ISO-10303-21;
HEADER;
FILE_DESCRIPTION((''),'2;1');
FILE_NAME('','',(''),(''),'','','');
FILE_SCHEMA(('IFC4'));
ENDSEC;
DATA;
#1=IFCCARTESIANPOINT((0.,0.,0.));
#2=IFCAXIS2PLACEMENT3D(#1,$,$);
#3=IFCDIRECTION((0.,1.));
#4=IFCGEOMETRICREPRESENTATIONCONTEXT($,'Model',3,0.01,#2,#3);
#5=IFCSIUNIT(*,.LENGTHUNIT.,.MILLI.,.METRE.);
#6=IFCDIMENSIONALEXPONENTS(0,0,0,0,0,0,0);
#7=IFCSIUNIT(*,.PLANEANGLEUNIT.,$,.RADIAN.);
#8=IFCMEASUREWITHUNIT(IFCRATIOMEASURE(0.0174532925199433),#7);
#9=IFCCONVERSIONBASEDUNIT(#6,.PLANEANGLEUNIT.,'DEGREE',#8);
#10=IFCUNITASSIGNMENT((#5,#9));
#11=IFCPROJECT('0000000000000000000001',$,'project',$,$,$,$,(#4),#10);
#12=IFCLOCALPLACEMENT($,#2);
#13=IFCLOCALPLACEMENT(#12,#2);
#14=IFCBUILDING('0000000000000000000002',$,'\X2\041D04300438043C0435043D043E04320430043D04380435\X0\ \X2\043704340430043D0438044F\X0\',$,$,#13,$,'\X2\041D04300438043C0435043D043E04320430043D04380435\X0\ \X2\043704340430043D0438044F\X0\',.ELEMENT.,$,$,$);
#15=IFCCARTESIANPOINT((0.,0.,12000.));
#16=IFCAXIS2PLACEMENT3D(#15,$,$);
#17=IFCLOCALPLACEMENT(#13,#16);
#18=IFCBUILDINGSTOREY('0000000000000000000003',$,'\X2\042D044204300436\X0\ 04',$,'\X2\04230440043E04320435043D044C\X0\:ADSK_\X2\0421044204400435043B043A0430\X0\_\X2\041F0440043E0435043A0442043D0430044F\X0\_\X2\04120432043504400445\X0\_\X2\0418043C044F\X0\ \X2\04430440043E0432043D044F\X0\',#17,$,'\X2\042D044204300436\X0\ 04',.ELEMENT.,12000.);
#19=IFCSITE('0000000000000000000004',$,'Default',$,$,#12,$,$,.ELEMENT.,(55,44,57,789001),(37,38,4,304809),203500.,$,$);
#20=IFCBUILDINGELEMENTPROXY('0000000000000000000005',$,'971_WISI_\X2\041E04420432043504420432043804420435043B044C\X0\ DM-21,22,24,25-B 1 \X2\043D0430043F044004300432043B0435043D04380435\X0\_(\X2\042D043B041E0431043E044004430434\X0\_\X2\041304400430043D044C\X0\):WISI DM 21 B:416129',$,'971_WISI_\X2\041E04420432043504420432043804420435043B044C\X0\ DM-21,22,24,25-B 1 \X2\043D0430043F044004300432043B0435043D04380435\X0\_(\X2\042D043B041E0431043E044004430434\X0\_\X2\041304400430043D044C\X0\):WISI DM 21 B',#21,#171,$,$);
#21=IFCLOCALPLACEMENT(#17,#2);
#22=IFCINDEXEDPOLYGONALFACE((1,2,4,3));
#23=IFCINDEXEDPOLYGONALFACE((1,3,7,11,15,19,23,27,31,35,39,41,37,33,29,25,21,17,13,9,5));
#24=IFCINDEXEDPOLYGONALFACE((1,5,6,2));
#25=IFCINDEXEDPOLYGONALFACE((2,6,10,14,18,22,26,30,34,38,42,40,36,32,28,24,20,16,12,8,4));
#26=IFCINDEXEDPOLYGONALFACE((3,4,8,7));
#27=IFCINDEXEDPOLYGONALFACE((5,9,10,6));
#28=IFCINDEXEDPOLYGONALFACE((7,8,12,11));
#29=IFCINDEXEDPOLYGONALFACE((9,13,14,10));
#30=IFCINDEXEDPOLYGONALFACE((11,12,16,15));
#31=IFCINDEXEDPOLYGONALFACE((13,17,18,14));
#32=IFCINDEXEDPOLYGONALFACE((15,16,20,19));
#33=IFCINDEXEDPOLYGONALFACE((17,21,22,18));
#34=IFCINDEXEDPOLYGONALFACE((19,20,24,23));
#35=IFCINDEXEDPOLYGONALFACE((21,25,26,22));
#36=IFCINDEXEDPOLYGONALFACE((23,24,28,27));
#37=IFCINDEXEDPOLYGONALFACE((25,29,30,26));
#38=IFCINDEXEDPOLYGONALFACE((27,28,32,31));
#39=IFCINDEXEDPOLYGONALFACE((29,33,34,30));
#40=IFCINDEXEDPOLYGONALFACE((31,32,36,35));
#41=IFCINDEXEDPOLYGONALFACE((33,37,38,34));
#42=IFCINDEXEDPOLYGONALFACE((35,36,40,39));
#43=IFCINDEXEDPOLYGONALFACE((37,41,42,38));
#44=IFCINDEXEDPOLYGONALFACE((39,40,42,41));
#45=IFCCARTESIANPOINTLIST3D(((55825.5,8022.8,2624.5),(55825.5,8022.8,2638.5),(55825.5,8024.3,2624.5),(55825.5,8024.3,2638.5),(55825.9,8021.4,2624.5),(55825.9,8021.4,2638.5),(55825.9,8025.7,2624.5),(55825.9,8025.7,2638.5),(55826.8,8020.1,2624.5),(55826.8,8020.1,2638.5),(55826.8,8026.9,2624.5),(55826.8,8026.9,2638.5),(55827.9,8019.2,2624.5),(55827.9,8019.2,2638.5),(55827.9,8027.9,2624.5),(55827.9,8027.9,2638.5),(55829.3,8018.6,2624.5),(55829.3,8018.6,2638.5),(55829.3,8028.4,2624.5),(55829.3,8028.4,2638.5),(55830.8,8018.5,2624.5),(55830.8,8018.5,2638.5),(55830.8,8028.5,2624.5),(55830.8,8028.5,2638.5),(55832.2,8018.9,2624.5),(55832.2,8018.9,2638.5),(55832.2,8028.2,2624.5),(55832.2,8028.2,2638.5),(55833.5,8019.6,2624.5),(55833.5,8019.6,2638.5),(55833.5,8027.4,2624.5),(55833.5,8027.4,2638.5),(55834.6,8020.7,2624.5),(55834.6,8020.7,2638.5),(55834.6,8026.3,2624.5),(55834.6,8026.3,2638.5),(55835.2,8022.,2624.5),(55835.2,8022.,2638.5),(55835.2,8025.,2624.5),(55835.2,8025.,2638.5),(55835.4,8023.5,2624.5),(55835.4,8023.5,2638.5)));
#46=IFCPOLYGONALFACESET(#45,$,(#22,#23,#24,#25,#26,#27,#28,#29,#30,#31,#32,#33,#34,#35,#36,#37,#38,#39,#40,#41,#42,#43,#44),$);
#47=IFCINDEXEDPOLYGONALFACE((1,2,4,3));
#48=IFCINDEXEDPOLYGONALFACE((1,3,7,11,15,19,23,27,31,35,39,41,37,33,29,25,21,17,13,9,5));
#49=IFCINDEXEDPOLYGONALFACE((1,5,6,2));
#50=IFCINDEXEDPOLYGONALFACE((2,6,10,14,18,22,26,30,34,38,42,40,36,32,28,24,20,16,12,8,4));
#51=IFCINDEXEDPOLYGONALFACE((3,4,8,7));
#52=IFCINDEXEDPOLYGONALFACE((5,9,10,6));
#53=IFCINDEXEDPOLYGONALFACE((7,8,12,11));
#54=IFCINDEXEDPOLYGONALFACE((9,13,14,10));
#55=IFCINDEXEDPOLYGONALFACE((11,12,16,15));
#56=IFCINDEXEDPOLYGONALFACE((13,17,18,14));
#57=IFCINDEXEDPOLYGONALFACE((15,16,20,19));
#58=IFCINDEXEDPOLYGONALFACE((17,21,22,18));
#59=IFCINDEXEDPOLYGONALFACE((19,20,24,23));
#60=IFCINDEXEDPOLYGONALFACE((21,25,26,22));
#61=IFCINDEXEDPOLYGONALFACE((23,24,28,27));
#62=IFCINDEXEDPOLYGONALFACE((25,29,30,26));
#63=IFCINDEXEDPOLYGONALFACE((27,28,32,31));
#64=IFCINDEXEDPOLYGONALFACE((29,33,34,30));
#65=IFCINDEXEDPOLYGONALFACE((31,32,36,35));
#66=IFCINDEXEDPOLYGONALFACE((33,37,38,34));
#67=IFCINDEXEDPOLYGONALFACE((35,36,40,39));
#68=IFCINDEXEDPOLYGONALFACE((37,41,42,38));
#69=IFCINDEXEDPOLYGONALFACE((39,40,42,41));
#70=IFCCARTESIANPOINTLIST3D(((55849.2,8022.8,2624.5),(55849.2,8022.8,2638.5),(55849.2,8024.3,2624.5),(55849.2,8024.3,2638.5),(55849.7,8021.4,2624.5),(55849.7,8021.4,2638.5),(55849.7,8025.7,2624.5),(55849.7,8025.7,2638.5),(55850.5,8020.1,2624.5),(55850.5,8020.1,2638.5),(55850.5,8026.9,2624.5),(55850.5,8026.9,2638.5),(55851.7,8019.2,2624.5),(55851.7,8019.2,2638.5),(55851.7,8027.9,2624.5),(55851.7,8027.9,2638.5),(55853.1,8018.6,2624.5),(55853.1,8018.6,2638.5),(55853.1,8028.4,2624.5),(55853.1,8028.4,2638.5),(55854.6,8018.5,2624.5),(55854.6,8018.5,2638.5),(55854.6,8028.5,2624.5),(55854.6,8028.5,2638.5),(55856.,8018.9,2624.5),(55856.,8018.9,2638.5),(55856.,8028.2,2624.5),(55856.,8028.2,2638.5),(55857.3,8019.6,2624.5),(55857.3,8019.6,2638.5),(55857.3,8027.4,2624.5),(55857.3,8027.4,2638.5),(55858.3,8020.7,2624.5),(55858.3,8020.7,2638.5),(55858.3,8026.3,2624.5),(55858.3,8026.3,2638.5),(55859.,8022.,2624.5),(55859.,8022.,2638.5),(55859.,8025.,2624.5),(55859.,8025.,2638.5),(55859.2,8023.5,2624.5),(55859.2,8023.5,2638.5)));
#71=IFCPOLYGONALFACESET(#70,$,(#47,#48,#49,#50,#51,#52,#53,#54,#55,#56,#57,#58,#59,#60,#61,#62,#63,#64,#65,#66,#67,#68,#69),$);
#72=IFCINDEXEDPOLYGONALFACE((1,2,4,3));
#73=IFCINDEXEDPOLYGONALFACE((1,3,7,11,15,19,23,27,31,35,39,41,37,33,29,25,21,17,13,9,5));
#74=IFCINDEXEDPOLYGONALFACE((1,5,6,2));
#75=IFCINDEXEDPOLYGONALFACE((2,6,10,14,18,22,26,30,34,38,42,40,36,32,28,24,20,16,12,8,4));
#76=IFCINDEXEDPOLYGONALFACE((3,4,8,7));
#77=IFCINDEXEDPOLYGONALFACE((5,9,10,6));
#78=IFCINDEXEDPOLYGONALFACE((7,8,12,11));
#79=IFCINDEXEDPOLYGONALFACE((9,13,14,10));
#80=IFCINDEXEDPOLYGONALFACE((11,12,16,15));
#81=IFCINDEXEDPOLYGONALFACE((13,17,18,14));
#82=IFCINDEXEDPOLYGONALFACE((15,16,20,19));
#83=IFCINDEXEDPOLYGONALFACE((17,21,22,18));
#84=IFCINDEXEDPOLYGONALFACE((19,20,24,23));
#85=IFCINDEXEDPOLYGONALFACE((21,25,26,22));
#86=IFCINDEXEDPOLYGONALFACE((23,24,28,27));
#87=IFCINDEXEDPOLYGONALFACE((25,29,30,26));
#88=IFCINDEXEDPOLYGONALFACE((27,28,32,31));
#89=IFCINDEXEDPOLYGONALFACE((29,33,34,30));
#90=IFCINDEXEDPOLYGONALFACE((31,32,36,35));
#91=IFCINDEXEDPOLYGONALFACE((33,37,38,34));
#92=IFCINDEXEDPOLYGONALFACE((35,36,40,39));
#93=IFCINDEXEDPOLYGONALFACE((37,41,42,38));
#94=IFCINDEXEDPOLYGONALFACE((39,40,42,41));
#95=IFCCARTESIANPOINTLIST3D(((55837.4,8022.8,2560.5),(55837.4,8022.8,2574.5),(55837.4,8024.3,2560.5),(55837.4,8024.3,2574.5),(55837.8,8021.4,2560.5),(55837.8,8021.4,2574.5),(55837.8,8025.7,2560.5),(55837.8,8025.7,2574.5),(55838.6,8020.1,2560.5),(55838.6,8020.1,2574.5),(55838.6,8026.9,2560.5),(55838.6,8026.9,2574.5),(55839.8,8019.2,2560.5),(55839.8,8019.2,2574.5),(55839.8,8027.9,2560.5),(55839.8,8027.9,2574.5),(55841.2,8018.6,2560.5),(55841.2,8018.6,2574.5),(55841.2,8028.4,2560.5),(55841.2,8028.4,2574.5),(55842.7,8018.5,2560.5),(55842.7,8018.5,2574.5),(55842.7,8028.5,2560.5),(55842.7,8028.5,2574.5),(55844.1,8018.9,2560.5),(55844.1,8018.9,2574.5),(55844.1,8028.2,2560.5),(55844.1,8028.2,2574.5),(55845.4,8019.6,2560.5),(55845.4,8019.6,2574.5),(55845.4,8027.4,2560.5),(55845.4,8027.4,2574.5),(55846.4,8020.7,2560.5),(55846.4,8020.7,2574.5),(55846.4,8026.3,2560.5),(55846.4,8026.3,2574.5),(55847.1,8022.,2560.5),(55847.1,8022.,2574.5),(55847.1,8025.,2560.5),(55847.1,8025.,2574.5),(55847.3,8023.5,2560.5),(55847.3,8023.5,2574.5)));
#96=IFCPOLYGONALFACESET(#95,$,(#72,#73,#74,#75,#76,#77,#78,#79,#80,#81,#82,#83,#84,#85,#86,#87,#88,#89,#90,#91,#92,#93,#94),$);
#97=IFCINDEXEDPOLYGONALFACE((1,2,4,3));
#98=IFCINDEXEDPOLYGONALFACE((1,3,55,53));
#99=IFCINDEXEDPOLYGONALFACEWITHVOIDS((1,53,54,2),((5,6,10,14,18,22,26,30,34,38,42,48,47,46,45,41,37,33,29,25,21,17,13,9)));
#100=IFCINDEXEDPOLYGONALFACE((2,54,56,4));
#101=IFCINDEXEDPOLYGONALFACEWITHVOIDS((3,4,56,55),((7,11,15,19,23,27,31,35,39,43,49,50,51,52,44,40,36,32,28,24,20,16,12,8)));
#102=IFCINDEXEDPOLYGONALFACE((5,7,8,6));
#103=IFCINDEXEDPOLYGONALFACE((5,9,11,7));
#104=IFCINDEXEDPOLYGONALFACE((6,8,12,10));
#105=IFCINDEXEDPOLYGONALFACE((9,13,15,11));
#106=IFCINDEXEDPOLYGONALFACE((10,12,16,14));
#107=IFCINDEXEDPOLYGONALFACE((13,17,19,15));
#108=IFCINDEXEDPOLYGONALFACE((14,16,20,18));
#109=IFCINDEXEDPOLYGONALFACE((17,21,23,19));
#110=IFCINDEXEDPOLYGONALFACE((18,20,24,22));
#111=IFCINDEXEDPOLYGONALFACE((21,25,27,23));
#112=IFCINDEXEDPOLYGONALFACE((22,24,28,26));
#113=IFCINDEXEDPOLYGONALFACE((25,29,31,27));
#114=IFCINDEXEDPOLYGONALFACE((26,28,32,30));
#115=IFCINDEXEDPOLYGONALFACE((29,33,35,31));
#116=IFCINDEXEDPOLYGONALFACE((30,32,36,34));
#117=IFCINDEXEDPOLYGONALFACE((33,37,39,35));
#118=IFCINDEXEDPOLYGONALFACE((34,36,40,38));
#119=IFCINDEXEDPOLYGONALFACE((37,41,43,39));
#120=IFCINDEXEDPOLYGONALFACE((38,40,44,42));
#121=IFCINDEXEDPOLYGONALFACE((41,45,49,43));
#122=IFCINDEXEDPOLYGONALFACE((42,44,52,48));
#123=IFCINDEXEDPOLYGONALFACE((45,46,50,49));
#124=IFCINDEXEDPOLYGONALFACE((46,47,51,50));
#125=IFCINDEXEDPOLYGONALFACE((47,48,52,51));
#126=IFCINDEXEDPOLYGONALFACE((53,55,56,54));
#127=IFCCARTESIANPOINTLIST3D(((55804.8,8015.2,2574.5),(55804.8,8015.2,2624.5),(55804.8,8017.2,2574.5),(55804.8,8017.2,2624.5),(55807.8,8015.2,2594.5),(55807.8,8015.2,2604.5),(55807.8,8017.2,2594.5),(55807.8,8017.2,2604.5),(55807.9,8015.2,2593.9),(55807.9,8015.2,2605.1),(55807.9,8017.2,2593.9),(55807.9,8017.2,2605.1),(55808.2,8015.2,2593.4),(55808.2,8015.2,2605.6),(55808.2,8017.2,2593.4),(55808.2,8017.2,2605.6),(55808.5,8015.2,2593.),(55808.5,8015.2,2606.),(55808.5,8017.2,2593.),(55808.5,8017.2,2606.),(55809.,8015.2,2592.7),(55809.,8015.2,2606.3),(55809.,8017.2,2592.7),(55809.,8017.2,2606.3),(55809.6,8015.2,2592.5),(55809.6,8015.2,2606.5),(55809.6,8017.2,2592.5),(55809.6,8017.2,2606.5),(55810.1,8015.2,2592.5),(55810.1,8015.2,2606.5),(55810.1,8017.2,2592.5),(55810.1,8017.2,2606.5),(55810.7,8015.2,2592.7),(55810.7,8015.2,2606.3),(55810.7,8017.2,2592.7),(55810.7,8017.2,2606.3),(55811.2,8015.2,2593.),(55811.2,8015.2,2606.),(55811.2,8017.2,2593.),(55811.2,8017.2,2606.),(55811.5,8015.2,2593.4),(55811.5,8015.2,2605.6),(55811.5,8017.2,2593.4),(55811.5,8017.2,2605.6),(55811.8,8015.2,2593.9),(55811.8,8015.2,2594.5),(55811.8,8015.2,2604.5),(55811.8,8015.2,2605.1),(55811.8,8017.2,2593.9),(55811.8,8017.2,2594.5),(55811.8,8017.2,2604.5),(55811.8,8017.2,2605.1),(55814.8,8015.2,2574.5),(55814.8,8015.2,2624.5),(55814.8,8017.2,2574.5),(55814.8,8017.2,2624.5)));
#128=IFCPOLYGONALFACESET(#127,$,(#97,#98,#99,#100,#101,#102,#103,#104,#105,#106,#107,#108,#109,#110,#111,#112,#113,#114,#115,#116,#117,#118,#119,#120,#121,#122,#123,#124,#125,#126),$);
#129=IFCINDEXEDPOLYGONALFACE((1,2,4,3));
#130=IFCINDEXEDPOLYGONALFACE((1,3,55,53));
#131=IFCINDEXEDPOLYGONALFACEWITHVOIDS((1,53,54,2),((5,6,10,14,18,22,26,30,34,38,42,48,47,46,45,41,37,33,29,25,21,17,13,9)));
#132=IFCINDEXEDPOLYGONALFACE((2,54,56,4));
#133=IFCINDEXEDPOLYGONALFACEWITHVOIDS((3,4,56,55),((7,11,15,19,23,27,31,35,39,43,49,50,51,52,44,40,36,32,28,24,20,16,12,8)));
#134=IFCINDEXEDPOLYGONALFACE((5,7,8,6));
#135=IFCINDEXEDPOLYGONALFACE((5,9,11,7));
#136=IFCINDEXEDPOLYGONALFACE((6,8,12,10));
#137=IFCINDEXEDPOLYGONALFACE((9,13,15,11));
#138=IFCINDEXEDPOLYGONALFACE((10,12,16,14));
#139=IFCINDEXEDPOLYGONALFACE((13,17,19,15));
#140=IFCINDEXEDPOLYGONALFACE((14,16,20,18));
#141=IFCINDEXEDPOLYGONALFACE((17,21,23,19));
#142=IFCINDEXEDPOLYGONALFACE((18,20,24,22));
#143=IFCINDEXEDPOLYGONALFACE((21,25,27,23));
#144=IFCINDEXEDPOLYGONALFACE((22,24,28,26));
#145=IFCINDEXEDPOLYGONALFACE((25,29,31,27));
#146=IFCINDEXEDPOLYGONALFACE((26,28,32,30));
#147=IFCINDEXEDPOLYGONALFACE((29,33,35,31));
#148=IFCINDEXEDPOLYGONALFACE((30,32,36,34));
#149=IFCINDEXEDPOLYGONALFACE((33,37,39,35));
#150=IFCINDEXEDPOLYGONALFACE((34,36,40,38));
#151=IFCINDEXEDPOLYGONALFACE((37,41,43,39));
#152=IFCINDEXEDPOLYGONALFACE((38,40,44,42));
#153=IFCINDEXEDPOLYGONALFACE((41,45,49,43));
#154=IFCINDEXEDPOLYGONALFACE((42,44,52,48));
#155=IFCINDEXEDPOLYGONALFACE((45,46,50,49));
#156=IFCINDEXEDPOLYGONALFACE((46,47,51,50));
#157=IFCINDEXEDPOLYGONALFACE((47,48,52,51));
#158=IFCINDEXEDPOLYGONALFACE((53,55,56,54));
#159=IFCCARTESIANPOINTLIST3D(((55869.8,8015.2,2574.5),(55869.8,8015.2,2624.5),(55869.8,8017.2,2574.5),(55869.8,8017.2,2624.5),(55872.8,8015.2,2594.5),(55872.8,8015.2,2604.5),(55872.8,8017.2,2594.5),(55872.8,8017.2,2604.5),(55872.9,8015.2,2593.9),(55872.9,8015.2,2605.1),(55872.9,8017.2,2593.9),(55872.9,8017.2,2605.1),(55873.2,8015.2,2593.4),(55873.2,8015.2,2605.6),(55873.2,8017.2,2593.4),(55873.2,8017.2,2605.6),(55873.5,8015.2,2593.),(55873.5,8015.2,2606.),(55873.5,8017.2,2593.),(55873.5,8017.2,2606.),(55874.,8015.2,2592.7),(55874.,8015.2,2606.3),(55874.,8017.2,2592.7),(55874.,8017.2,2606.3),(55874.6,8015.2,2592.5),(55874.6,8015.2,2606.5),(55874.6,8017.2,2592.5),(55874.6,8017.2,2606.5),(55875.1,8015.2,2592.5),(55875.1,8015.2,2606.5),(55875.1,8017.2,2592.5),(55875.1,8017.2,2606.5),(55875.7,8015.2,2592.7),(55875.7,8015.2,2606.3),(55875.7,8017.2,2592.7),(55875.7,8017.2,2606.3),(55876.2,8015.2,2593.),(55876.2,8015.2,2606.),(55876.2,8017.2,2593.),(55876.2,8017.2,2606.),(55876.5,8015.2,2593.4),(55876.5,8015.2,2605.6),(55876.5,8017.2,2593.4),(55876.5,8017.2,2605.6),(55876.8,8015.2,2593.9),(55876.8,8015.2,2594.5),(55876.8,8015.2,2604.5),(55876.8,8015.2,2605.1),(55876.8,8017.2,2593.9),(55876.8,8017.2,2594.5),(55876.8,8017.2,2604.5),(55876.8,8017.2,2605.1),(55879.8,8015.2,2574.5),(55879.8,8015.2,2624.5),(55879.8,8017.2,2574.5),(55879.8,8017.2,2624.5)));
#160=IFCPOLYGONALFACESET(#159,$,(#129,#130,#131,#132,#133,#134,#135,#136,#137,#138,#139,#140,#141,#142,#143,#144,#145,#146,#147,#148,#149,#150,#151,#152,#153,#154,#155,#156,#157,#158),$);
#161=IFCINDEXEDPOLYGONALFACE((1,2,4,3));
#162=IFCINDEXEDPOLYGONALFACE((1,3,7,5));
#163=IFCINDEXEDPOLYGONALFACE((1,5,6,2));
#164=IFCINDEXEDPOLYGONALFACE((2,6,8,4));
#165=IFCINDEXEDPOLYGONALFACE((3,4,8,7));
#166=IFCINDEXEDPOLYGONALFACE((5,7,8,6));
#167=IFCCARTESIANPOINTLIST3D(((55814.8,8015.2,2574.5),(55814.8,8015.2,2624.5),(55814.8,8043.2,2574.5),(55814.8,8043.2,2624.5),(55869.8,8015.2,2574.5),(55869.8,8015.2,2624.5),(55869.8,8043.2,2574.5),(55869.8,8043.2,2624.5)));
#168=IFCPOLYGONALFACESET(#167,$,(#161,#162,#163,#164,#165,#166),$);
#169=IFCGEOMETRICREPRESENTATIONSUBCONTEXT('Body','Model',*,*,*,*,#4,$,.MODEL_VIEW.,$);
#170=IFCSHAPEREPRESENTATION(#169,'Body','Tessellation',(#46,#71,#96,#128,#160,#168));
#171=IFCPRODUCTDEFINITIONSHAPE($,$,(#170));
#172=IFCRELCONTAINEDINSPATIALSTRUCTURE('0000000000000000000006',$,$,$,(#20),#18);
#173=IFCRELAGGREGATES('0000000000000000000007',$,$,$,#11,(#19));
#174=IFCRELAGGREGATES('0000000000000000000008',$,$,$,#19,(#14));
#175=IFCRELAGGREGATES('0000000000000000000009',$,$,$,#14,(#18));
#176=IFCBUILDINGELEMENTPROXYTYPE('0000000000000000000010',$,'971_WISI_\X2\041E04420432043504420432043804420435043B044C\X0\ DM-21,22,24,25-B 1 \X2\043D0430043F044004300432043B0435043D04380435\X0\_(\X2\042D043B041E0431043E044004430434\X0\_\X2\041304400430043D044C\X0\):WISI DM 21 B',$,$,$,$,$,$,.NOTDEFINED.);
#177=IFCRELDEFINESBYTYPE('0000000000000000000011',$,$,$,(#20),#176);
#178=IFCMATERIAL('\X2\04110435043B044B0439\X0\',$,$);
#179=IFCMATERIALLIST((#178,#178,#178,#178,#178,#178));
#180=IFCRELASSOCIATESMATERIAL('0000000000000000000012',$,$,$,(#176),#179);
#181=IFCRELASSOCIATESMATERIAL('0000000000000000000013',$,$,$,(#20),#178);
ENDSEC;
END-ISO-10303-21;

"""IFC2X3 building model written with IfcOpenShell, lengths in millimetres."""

from ifc_helpers import new_model, entity, si_unit, converted_unit, direction, frame, origin, origin_2d_with_axis, place, context, subcontext, project, spatial, rectangle, circle, extrude, source, transform, mapped, material, material_list, type_object, type_shapes, element, save


model = new_model("IFC2X3")

# Units and contexts
model_context = context("Model", 3, precision=0.01, world=origin(), true_north=direction((0.0, 1.0)))
body_context = subcontext(model_context, "Body", "Model", "MODEL_VIEW")
ifc_project = project(units=[si_unit("LENGTHUNIT", "METRE", prefix="MILLI"), converted_unit("PLANEANGLEUNIT", "DEGREE", entity("IfcRatioMeasure", 0.0174532925199433), si_unit("PLANEANGLEUNIT", "RADIAN"), dimensions=[0, 0, 0, 0, 0, 0, 0])], contexts=[model_context])

# Site, building, storey
site_placement = place(None, origin())
site = spatial("IfcSite", under=ifc_project, at=site_placement, Name="Default", CompositionType="ELEMENT", RefLatitude=(55, 44, 57, 789001), RefLongitude=(37, 38, 4, 304809), RefElevation=203500.0)
building_placement = place(site_placement, origin())
building = spatial("IfcBuilding", under=site, at=building_placement, Name="Наименование здания", LongName="Наименование здания", CompositionType="ELEMENT")
storey_placement = place(building_placement, frame((0.0, 0.0, 12000.0)))
storey = spatial("IfcBuildingStorey", under=building, at=storey_placement, Name="Этаж 04", ObjectType="Уровень:ADSK_Стрелка_Проектная_Вверх_Имя уровня", LongName="Этаж 04", CompositionType="ELEMENT", Elevation=12000.0)

# Building element proxy
ifc_material = material(Name="Белый")
ifc_material_list = material_list([ifc_material, ifc_material, ifc_material, ifc_material, ifc_material, ifc_material])
building_element_proxy_type = type_object("IfcBuildingElementProxyType", Name="971_WISI_Ответвитель DM-21,22,24,25-B 1 направление_(ЭлОборуд_Грань):WISI DM 21 B", PredefinedType="NOTDEFINED", material=ifc_material_list)
cartesian_point = entity("IfcCartesianPoint", [-5.0, -25.0])
shared_polyline = entity("IfcPolyline", [cartesian_point, entity("IfcCartesianPoint", [5.0, -25.0]), entity("IfcCartesianPoint", [5.0, 25.0]), entity("IfcCartesianPoint", [-5.0, 25.0]), cartesian_point])
ifc_direction_1 = entity("IfcDirection", [-1.0, 0.0])
ifc_direction_2 = entity("IfcDirection", [0.0, 0.0, 1.0])
ifc_direction_3 = entity("IfcDirection", [-1.0, 0.0])
ifc_direction_4 = entity("IfcDirection", [0.0, 0.0, 1.0])
shared_shape = source(origin(), body_context, "Body", "SweptSolid", [
    extrude(circle(Radius=5.0, at=origin_2d_with_axis()), frame((11.9, 25.0, 8.4), z_axis=(0.0, 1.0, 0.0), x_axis=(-1.0, 0.0, 0.0)), (0.0, 0.0, 1.0), 14.0),
    extrude(circle(Radius=5.0, at=origin_2d_with_axis()), frame((-11.8, 25.0, 8.4), z_axis=(0.0, 1.0, 0.0), x_axis=(-1.0, 0.0, 0.0)), (0.0, 0.0, 1.0), 14.0),
    extrude(circle(Radius=5.0, at=origin_2d_with_axis()), frame((0.0, -39.0, 8.4), z_axis=(0.0, 1.0, 0.0), x_axis=(-1.0, 0.0, 0.0)), (0.0, 0.0, 1.0), 14.0),
    entity("IfcExtrudedAreaSolid", entity("IfcArbitraryProfileDefWithVoids", "AREA", None, shared_polyline, [entity("IfcCompositeCurve", [entity("IfcCompositeCurveSegment", "CONTINUOUS", True, entity("IfcPolyline", [entity("IfcCartesianPoint", [2.0, 5.0]), entity("IfcCartesianPoint", [2.0, -5.0])])), entity("IfcCompositeCurveSegment", "CONTINUOUS", False, entity("IfcTrimmedCurve", entity("IfcCircle", entity("IfcAxis2Placement2D", entity("IfcCartesianPoint", [0.0, -5.0]), ifc_direction_1), 2.0), [entity("IfcParameterValue", 0.0)], [entity("IfcParameterValue", 180.0)], True, "PARAMETER")), entity("IfcCompositeCurveSegment", "CONTINUOUS", True, entity("IfcPolyline", [entity("IfcCartesianPoint", [-2.0, -5.0]), entity("IfcCartesianPoint", [-2.0, 5.0])])), entity("IfcCompositeCurveSegment", "CONTINUOUS", False, entity("IfcTrimmedCurve", entity("IfcCircle", entity("IfcAxis2Placement2D", entity("IfcCartesianPoint", [0.0, 5.0]), ifc_direction_1), 2.0), [entity("IfcParameterValue", 180.0)], [entity("IfcParameterValue", 0.0)], True, "PARAMETER"))], False)]), entity("IfcAxis2Placement3D", entity("IfcCartesianPoint", [32.5, 0.0, 0.0]), ifc_direction_2, entity("IfcDirection", [-1.0, 0.0, 0.0])), ifc_direction_2, 2.0),
    entity("IfcExtrudedAreaSolid", entity("IfcArbitraryProfileDefWithVoids", "AREA", None, shared_polyline, [entity("IfcCompositeCurve", [entity("IfcCompositeCurveSegment", "CONTINUOUS", True, entity("IfcPolyline", [entity("IfcCartesianPoint", [-2.0, -5.0]), entity("IfcCartesianPoint", [-2.0, 5.0])])), entity("IfcCompositeCurveSegment", "CONTINUOUS", False, entity("IfcTrimmedCurve", entity("IfcCircle", entity("IfcAxis2Placement2D", entity("IfcCartesianPoint", [0.0, 5.0]), ifc_direction_3), 2.0), [entity("IfcParameterValue", 180.0)], [entity("IfcParameterValue", 0.0)], True, "PARAMETER")), entity("IfcCompositeCurveSegment", "CONTINUOUS", True, entity("IfcPolyline", [entity("IfcCartesianPoint", [2.0, 5.0]), entity("IfcCartesianPoint", [2.0, -5.0])])), entity("IfcCompositeCurveSegment", "CONTINUOUS", False, entity("IfcTrimmedCurve", entity("IfcCircle", entity("IfcAxis2Placement2D", entity("IfcCartesianPoint", [0.0, -5.0]), ifc_direction_3), 2.0), [entity("IfcParameterValue", 0.0)], [entity("IfcParameterValue", 180.0)], True, "PARAMETER"))], False)]), entity("IfcAxis2Placement3D", entity("IfcCartesianPoint", [-32.5, 0.0, 0.0]), ifc_direction_4, entity("IfcDirection", [-1.0, 0.0, 0.0])), ifc_direction_4, 2.0),
    extrude(rectangle(XDim=55.0, YDim=50.0, at=origin_2d_with_axis()), frame((0.0, 0.0, 0.0), z_axis=(0.0, 0.0, 1.0), x_axis=(-1.0, 0.0, 0.0)), (0.0, 0.0, 1.0), 28.0),
])
type_shapes(building_element_proxy_type, [shared_shape])
for number, where, z_axis, x_axis, name in (
    (1, (55842.3, 8015.1, 2599.5), (0.0, 1.0, 0.0), (-1.0, 0.0, 0.0), "971_WISI_Ответвитель DM-21,22,24,25-B 1 направление_(ЭлОборуд_Грань):WISI DM 21 B:416129"),
):
    element("IfcBuildingElementProxy", number, at=place(storey_placement, frame(where, z_axis=z_axis, x_axis=x_axis)), inside=storey, type_object=building_element_proxy_type, material=ifc_material, Name=name, ObjectType="971_WISI_Ответвитель DM-21,22,24,25-B 1 направление_(ЭлОборуд_Грань):WISI DM 21 B", context=body_context, shape_type="MappedRepresentation", body=[
        mapped(shared_shape, transform((0.0, 0.0, 0.0), scale=1.0)),
    ])

save(model, "model.ifc")
